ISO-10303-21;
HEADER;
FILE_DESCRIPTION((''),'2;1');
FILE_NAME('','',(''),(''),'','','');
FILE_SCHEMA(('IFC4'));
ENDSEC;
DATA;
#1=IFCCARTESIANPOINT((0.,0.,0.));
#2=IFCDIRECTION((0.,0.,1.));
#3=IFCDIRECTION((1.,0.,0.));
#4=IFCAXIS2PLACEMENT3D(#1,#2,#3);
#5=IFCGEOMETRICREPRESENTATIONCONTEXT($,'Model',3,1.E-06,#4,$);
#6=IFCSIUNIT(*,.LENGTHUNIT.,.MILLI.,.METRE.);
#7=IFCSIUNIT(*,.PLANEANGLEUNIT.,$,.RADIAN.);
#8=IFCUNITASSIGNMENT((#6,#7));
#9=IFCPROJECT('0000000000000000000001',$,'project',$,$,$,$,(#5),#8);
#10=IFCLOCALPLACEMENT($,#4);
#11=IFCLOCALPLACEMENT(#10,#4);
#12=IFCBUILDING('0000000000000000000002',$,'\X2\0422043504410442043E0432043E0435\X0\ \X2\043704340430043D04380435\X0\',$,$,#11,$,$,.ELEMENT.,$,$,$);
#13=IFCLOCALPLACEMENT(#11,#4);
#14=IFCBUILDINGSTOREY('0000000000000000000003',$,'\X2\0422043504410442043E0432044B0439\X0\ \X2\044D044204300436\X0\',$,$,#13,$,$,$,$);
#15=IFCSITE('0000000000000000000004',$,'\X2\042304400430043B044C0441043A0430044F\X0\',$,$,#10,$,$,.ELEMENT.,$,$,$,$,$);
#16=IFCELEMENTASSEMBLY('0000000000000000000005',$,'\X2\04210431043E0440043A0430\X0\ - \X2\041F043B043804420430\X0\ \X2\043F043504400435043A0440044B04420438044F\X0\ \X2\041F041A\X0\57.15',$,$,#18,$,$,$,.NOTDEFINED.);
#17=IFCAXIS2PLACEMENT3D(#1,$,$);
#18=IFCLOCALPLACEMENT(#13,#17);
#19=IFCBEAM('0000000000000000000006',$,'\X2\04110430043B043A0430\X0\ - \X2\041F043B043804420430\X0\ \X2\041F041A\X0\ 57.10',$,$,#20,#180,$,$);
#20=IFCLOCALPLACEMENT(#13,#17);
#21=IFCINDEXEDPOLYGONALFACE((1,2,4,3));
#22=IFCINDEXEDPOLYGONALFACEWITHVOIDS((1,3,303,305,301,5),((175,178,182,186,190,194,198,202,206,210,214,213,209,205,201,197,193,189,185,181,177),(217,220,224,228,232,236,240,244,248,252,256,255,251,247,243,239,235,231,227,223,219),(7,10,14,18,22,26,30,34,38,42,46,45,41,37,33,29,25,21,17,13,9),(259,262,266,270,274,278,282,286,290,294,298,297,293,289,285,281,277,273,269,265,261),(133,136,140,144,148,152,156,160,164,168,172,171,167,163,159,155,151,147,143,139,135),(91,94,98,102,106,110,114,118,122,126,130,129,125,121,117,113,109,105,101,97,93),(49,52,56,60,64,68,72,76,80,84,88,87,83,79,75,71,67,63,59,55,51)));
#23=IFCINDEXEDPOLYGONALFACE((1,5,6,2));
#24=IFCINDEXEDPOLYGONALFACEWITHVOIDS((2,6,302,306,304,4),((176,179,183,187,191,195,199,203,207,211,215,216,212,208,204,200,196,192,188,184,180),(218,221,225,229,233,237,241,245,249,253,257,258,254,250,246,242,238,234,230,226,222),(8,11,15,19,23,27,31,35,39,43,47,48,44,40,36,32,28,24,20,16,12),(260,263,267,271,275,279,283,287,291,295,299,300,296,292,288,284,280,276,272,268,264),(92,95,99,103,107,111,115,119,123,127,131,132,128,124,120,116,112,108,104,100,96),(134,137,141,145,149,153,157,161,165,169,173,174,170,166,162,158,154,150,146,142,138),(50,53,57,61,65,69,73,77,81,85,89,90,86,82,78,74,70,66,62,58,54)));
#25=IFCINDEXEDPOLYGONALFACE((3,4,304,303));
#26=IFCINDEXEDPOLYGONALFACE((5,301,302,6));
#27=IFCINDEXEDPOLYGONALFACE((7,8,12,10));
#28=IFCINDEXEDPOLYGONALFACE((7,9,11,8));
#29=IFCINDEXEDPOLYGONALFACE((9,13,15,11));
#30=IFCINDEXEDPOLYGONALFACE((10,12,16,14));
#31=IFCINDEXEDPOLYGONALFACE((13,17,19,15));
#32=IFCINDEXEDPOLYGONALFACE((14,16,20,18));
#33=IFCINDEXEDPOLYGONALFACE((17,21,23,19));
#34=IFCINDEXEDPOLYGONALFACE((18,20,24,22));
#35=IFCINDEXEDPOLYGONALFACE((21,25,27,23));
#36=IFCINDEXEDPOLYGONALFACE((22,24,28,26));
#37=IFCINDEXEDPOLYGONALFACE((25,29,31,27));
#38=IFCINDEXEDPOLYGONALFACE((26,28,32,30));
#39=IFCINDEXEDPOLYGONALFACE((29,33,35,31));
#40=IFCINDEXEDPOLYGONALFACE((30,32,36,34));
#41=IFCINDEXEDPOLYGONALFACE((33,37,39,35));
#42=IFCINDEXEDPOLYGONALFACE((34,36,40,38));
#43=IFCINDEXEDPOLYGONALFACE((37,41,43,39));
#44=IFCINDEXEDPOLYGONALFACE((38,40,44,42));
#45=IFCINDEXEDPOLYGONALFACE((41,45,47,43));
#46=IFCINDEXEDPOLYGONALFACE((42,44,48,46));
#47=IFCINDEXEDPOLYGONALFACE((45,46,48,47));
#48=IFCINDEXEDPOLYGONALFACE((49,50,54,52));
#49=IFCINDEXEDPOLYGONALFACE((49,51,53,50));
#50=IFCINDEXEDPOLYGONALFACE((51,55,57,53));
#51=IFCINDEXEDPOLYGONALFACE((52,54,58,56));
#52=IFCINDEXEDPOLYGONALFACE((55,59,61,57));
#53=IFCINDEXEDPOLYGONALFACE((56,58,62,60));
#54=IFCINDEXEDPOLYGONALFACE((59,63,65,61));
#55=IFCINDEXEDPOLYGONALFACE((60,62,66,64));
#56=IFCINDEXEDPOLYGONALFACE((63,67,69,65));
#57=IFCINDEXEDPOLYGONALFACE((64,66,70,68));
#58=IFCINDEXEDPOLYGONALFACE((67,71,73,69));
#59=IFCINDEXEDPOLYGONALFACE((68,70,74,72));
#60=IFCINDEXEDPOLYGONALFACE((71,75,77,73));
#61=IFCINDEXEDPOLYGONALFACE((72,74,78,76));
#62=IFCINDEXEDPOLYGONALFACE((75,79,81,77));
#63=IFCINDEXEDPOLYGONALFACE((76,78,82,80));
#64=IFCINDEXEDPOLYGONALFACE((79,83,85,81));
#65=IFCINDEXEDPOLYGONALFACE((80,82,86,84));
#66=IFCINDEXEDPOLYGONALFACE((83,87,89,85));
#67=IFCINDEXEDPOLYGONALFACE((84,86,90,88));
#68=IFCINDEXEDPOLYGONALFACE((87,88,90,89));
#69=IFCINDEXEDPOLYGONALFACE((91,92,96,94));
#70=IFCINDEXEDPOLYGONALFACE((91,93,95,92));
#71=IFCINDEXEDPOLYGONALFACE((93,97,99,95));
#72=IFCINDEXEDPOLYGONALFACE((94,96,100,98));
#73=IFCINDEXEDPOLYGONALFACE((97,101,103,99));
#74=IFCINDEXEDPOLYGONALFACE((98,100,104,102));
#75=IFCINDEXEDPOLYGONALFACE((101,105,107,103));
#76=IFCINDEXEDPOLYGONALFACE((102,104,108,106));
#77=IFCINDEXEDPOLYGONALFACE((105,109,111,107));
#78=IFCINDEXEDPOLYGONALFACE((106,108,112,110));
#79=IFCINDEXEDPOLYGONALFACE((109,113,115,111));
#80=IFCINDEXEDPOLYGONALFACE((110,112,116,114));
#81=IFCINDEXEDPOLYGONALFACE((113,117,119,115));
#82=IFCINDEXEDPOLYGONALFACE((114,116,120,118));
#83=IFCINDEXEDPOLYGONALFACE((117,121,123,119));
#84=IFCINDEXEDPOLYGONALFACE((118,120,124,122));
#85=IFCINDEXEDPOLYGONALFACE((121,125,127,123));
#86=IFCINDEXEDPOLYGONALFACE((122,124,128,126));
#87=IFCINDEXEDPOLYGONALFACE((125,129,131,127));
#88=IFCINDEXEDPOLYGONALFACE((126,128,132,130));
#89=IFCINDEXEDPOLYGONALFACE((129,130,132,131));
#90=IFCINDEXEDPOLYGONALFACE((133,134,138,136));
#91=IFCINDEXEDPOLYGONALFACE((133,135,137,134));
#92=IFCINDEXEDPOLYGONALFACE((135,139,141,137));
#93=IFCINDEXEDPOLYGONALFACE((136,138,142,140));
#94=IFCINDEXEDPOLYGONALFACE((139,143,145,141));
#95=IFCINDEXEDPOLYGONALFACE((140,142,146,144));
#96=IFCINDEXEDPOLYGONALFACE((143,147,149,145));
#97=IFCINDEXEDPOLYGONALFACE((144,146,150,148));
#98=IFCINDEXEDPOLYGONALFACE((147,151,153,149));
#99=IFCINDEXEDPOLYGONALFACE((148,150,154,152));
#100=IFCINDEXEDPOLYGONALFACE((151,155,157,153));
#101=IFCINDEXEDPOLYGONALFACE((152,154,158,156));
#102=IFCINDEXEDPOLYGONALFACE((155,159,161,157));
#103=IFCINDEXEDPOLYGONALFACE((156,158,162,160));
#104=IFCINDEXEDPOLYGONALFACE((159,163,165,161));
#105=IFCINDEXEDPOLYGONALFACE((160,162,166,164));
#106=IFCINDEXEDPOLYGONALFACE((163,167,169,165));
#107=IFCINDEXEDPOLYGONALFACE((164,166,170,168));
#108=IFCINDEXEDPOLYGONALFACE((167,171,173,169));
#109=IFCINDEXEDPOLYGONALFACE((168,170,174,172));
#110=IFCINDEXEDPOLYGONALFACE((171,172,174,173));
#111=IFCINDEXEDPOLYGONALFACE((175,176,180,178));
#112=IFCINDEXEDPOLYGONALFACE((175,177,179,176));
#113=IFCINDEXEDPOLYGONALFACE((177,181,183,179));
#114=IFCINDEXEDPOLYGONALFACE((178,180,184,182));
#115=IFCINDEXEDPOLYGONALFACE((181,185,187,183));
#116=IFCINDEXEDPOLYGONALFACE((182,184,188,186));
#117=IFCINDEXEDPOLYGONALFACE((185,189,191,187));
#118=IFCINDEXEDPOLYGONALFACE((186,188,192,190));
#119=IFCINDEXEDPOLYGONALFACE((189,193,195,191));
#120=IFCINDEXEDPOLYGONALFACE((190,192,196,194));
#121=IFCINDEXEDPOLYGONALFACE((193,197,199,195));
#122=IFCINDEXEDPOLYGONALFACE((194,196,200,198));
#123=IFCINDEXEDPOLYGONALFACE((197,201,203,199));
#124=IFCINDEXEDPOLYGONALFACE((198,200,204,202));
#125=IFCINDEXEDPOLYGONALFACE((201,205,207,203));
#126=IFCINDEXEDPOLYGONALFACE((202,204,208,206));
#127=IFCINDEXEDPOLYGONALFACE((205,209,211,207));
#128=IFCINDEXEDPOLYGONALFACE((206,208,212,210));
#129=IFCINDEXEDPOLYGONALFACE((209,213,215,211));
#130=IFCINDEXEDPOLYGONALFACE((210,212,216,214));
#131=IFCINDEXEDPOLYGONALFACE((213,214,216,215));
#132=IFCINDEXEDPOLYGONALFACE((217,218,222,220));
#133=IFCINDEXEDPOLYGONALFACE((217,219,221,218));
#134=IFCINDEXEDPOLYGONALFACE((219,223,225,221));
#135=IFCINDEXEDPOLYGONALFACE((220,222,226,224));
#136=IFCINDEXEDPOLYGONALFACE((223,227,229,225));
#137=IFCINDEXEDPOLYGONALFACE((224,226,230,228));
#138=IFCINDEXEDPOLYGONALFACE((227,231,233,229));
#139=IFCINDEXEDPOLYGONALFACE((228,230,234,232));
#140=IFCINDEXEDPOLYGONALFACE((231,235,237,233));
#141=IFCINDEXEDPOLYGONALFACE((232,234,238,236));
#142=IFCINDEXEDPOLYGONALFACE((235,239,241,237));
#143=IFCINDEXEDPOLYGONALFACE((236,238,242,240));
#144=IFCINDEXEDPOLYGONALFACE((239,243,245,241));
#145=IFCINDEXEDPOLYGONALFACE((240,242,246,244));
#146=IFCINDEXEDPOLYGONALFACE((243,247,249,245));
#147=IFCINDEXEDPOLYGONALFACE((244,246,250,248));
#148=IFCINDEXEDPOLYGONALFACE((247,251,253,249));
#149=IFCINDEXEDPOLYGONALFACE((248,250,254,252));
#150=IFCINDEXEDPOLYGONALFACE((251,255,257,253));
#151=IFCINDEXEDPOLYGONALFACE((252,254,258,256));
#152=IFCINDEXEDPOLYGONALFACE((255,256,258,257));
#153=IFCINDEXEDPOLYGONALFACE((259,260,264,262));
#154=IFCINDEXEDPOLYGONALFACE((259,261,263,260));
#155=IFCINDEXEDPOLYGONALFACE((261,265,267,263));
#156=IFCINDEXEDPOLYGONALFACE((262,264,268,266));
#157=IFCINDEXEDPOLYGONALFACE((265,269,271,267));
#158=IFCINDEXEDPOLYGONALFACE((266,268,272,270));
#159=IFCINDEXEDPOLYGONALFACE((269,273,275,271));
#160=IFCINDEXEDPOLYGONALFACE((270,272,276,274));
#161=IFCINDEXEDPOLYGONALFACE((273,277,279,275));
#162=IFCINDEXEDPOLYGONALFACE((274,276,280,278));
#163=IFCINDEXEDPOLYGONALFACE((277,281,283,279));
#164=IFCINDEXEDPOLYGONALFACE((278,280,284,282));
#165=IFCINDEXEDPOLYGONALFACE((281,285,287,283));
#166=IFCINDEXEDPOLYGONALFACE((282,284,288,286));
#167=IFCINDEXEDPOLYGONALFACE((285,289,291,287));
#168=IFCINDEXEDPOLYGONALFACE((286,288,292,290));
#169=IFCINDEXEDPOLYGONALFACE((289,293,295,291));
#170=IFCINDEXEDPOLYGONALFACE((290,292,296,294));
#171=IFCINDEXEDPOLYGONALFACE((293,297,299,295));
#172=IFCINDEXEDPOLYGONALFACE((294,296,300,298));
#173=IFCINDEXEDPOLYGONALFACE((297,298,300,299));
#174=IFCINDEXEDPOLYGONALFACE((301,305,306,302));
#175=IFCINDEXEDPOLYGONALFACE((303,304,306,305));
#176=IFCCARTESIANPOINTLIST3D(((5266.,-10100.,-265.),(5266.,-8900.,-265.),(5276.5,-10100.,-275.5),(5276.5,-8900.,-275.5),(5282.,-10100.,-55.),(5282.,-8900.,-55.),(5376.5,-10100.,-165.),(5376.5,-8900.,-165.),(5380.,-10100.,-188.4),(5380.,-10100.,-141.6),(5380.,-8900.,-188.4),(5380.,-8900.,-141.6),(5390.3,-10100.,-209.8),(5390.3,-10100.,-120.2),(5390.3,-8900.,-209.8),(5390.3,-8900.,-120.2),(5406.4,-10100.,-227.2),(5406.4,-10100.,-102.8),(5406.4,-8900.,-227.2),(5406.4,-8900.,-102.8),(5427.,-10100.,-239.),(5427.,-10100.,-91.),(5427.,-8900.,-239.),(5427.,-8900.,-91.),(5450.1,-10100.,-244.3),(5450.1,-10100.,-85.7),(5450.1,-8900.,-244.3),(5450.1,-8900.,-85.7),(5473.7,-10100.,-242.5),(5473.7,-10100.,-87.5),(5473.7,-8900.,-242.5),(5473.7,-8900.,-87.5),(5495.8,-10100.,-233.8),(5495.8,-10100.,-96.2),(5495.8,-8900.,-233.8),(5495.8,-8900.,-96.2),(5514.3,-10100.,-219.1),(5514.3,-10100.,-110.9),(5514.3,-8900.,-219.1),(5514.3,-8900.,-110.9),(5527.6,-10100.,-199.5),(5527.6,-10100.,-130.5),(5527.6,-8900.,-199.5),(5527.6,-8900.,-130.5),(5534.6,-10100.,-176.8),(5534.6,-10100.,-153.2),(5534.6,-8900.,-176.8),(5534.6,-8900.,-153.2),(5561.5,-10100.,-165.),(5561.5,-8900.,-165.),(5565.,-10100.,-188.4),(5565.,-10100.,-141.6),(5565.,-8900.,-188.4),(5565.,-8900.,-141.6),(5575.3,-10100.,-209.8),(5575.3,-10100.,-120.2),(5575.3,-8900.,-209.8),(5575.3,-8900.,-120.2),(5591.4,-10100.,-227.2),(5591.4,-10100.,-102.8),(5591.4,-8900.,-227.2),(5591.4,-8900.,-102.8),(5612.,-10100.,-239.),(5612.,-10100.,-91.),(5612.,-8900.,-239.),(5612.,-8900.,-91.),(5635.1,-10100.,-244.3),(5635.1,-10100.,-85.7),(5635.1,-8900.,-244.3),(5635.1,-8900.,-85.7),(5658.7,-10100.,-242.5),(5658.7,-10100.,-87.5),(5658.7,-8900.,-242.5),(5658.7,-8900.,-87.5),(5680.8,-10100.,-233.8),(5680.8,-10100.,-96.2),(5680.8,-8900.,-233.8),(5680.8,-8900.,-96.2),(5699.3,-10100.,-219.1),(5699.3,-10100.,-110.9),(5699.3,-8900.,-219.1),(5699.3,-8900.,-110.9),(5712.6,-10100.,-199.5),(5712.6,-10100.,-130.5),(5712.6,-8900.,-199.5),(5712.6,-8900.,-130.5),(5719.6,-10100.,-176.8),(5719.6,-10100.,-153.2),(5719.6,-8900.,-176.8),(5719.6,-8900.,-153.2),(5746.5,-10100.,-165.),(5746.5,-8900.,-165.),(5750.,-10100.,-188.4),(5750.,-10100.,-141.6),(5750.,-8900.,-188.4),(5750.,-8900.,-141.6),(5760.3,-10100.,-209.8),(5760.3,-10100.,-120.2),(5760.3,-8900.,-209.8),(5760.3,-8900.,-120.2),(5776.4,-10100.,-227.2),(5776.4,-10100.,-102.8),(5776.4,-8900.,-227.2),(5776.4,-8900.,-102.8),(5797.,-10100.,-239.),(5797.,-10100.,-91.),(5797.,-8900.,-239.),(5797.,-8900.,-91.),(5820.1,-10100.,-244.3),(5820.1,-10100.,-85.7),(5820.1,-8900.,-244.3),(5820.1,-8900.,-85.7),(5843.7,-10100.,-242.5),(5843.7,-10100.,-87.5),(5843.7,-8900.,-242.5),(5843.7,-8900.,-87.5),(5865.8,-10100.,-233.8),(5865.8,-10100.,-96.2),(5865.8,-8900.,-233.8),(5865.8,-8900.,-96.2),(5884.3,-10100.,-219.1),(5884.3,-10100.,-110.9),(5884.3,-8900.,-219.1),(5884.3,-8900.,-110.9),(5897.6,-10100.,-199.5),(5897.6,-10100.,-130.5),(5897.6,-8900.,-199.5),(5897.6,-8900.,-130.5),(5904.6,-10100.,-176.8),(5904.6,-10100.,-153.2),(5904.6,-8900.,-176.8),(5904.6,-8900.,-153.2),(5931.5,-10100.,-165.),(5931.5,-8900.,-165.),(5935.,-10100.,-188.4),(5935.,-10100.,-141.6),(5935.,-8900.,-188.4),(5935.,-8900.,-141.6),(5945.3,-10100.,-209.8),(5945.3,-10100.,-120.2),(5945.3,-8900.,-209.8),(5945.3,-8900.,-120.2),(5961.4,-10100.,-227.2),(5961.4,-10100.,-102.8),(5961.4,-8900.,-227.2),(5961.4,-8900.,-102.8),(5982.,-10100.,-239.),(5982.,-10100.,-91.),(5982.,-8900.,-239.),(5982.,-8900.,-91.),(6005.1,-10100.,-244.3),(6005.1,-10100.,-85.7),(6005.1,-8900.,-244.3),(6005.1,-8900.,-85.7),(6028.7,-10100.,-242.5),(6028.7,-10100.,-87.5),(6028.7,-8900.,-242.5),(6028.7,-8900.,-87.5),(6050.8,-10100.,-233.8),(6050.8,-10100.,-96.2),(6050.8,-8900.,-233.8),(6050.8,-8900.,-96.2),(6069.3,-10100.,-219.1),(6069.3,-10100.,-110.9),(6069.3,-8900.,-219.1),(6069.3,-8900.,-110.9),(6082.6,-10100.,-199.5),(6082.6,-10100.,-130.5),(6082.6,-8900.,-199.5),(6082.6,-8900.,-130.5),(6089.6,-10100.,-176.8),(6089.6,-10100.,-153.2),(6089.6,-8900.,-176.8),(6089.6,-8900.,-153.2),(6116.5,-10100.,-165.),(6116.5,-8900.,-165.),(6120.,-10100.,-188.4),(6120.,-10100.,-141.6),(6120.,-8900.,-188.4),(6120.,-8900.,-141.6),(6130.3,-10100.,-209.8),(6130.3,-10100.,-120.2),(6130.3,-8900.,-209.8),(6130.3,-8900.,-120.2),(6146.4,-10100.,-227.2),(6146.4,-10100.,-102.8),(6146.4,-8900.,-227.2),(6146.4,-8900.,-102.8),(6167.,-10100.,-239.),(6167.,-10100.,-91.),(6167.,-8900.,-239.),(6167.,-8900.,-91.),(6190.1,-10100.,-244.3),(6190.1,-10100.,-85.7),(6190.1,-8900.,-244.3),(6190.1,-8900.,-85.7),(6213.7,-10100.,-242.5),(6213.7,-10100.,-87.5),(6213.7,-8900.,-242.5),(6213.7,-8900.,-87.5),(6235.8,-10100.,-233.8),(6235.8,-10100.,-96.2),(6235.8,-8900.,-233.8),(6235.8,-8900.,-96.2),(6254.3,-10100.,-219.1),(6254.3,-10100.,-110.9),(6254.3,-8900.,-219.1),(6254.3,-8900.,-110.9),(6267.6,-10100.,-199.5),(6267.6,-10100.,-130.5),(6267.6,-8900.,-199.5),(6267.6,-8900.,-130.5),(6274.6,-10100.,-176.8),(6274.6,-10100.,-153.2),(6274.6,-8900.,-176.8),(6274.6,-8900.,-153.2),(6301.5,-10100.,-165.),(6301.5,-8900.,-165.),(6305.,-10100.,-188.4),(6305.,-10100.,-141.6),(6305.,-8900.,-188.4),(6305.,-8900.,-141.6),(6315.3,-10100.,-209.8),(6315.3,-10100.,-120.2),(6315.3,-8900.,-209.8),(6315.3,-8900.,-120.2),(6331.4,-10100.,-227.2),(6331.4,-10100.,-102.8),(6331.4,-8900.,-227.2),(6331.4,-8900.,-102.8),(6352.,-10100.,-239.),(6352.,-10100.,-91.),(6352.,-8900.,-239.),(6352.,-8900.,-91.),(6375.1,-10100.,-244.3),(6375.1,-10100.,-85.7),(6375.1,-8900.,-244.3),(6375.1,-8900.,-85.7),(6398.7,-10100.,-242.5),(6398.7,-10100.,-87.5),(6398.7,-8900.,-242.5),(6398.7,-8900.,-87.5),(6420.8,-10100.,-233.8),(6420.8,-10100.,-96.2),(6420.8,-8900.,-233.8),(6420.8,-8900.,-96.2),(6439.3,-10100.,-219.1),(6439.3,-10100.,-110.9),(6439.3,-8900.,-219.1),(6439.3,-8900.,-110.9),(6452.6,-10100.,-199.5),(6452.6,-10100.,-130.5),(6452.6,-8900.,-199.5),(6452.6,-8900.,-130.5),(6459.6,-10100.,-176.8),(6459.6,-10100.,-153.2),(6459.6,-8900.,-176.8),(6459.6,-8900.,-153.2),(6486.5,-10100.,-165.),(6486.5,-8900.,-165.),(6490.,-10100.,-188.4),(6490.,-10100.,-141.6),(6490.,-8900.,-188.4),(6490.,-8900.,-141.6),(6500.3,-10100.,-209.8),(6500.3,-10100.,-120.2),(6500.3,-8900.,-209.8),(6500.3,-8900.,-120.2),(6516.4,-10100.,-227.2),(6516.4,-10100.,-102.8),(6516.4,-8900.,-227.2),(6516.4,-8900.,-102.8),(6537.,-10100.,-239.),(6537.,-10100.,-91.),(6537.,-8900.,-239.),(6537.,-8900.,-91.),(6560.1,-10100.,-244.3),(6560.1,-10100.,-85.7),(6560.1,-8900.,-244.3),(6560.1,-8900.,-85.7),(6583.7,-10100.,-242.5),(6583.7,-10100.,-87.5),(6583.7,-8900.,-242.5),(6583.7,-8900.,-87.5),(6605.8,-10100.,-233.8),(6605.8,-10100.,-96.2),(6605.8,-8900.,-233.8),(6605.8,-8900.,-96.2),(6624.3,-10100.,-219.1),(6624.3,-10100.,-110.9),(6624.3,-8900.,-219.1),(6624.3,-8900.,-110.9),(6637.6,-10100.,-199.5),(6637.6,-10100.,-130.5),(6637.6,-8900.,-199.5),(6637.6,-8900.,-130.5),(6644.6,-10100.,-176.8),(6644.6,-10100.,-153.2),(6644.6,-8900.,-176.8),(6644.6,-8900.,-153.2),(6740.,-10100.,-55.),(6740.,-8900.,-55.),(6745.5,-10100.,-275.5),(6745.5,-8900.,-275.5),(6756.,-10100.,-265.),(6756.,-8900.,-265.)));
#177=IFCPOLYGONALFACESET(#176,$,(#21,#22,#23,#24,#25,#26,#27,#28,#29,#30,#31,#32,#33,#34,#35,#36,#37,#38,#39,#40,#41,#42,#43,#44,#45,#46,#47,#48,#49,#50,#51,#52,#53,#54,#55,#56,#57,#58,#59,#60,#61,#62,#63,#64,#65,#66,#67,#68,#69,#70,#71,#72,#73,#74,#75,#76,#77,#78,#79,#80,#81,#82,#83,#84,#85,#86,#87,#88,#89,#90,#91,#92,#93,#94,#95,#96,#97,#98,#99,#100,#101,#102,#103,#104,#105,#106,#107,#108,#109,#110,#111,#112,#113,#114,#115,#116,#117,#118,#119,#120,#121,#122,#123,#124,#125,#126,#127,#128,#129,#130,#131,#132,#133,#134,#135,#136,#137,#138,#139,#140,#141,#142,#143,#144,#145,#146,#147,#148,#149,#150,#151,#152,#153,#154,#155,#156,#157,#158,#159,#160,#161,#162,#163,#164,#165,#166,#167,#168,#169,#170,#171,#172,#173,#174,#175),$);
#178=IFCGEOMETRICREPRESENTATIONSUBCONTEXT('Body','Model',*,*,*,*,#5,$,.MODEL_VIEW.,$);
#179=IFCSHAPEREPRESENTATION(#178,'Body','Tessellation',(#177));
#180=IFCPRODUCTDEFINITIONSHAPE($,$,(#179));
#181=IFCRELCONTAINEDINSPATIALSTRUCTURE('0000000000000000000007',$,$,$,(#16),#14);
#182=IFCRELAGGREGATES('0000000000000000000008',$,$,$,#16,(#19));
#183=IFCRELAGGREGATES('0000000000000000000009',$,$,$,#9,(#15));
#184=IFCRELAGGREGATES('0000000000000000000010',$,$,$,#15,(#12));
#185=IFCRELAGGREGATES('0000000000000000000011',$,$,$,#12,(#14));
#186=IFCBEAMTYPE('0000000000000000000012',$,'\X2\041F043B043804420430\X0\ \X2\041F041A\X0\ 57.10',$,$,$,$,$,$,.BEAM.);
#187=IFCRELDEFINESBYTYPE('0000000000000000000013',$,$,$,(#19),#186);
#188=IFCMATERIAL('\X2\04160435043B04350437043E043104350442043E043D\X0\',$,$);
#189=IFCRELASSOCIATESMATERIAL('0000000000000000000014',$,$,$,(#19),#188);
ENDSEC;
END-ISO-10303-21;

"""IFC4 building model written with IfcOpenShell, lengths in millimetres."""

from ifc_helpers import new_model, si_unit, frame, frame_2d, origin_with_axes, place, context, subcontext, project, spatial, line, indexed_curve, circle_curve, outline, extrude, source, transform, mapped, material, type_object, element, aggregate, save


model = new_model("IFC4")

# Units and contexts
model_context = context("Model", 3, precision=1e-06, world=origin_with_axes())
body_context = subcontext(model_context, "Body", "Model", "MODEL_VIEW")
ifc_project = project(units=[si_unit("LENGTHUNIT", "METRE", prefix="MILLI"), si_unit("PLANEANGLEUNIT", "RADIAN")], contexts=[model_context])

# Site, building, storey
site_placement = place(None, origin_with_axes())
site = spatial("IfcSite", under=ifc_project, at=site_placement, Name="Уральская", CompositionType="ELEMENT")
building_placement = place(site_placement, origin_with_axes())
building = spatial("IfcBuilding", under=site, at=building_placement, Name="Тестовое здание", CompositionType="ELEMENT")
storey_placement = place(building_placement, origin_with_axes())
storey = spatial("IfcBuildingStorey", under=building, at=storey_placement, Name="Тестовый этаж")

# Element assembly, beam
assembly_1_placement = place(storey_placement, frame((6011.0, -9650.0, -55.0), z_axis=(0.0, 0.0, 1.0), x_axis=(1.0, 0.0, 0.0)))
assembly_1 = element("IfcElementAssembly", 1, at=assembly_1_placement, inside=storey, Name="Сборка - Плита перекрытия ПК57.15", PredefinedType="NOTDEFINED")
ifc_material_1 = material(Name="Железобетон")
beam_type_1 = type_object("IfcBeamType", Name="Плита ПК 57.10", PredefinedType="BEAM")
shared_shape_1 = source(origin_with_axes(), body_context, "Body", "SweptSolid", [
    extrude(outline(indexed_curve([(-729.0, 0.0), (-745.0, -210.0), (-734.5, -220.5), (734.5, -220.5), (745.0, -210.0), (729.0, 0.0)], segments=[line(1, 2), line(2, 3), line(3, 4), line(4, 5), line(5, 6), line(6, 1)]), holes=[circle_curve(frame_2d((555.0, -110.0), x_axis=(1.0, 0.0)), 79.5), circle_curve(frame_2d((370.0, -110.0), x_axis=(1.0, 0.0)), 79.5), circle_curve(frame_2d((185.0, -110.0), x_axis=(1.0, 0.0)), 79.5), circle_curve(frame_2d((-555.0, -110.0), x_axis=(1.0, 0.0)), 79.5), circle_curve(frame_2d((-370.0, -110.0), x_axis=(1.0, 0.0)), 79.5), circle_curve(frame_2d((-185.0, -110.0), x_axis=(1.0, 0.0)), 79.5), circle_curve(frame_2d((0.0, -110.0), x_axis=(1.0, 0.0)), 79.5)]), origin_with_axes(), (0.0, 0.0, -1.0), 1200.0),
])
beam_1_placement = place(assembly_1_placement, frame((0.0, 750.0, 0.0), z_axis=(0.0, 1.0, 0.0), x_axis=(-1.0, 0.0, 0.0)))
beam_1 = element("IfcBeam", 2, at=beam_1_placement, type_object=beam_type_1, material=ifc_material_1, Name="Балка - Плита ПК 57.10", context=body_context, shape_type="MappedRepresentation", body=[
    mapped(shared_shape_1, transform((0.0, 0.0, 0.0), x_axis=(1.0, 0.0, 0.0), y_axis=(0.0, 1.0, 0.0), z_axis=(0.0, 0.0, 1.0), scale=1.0)),
])
aggregate(assembly_1, [beam_1])

save(model, "model.ifc")
